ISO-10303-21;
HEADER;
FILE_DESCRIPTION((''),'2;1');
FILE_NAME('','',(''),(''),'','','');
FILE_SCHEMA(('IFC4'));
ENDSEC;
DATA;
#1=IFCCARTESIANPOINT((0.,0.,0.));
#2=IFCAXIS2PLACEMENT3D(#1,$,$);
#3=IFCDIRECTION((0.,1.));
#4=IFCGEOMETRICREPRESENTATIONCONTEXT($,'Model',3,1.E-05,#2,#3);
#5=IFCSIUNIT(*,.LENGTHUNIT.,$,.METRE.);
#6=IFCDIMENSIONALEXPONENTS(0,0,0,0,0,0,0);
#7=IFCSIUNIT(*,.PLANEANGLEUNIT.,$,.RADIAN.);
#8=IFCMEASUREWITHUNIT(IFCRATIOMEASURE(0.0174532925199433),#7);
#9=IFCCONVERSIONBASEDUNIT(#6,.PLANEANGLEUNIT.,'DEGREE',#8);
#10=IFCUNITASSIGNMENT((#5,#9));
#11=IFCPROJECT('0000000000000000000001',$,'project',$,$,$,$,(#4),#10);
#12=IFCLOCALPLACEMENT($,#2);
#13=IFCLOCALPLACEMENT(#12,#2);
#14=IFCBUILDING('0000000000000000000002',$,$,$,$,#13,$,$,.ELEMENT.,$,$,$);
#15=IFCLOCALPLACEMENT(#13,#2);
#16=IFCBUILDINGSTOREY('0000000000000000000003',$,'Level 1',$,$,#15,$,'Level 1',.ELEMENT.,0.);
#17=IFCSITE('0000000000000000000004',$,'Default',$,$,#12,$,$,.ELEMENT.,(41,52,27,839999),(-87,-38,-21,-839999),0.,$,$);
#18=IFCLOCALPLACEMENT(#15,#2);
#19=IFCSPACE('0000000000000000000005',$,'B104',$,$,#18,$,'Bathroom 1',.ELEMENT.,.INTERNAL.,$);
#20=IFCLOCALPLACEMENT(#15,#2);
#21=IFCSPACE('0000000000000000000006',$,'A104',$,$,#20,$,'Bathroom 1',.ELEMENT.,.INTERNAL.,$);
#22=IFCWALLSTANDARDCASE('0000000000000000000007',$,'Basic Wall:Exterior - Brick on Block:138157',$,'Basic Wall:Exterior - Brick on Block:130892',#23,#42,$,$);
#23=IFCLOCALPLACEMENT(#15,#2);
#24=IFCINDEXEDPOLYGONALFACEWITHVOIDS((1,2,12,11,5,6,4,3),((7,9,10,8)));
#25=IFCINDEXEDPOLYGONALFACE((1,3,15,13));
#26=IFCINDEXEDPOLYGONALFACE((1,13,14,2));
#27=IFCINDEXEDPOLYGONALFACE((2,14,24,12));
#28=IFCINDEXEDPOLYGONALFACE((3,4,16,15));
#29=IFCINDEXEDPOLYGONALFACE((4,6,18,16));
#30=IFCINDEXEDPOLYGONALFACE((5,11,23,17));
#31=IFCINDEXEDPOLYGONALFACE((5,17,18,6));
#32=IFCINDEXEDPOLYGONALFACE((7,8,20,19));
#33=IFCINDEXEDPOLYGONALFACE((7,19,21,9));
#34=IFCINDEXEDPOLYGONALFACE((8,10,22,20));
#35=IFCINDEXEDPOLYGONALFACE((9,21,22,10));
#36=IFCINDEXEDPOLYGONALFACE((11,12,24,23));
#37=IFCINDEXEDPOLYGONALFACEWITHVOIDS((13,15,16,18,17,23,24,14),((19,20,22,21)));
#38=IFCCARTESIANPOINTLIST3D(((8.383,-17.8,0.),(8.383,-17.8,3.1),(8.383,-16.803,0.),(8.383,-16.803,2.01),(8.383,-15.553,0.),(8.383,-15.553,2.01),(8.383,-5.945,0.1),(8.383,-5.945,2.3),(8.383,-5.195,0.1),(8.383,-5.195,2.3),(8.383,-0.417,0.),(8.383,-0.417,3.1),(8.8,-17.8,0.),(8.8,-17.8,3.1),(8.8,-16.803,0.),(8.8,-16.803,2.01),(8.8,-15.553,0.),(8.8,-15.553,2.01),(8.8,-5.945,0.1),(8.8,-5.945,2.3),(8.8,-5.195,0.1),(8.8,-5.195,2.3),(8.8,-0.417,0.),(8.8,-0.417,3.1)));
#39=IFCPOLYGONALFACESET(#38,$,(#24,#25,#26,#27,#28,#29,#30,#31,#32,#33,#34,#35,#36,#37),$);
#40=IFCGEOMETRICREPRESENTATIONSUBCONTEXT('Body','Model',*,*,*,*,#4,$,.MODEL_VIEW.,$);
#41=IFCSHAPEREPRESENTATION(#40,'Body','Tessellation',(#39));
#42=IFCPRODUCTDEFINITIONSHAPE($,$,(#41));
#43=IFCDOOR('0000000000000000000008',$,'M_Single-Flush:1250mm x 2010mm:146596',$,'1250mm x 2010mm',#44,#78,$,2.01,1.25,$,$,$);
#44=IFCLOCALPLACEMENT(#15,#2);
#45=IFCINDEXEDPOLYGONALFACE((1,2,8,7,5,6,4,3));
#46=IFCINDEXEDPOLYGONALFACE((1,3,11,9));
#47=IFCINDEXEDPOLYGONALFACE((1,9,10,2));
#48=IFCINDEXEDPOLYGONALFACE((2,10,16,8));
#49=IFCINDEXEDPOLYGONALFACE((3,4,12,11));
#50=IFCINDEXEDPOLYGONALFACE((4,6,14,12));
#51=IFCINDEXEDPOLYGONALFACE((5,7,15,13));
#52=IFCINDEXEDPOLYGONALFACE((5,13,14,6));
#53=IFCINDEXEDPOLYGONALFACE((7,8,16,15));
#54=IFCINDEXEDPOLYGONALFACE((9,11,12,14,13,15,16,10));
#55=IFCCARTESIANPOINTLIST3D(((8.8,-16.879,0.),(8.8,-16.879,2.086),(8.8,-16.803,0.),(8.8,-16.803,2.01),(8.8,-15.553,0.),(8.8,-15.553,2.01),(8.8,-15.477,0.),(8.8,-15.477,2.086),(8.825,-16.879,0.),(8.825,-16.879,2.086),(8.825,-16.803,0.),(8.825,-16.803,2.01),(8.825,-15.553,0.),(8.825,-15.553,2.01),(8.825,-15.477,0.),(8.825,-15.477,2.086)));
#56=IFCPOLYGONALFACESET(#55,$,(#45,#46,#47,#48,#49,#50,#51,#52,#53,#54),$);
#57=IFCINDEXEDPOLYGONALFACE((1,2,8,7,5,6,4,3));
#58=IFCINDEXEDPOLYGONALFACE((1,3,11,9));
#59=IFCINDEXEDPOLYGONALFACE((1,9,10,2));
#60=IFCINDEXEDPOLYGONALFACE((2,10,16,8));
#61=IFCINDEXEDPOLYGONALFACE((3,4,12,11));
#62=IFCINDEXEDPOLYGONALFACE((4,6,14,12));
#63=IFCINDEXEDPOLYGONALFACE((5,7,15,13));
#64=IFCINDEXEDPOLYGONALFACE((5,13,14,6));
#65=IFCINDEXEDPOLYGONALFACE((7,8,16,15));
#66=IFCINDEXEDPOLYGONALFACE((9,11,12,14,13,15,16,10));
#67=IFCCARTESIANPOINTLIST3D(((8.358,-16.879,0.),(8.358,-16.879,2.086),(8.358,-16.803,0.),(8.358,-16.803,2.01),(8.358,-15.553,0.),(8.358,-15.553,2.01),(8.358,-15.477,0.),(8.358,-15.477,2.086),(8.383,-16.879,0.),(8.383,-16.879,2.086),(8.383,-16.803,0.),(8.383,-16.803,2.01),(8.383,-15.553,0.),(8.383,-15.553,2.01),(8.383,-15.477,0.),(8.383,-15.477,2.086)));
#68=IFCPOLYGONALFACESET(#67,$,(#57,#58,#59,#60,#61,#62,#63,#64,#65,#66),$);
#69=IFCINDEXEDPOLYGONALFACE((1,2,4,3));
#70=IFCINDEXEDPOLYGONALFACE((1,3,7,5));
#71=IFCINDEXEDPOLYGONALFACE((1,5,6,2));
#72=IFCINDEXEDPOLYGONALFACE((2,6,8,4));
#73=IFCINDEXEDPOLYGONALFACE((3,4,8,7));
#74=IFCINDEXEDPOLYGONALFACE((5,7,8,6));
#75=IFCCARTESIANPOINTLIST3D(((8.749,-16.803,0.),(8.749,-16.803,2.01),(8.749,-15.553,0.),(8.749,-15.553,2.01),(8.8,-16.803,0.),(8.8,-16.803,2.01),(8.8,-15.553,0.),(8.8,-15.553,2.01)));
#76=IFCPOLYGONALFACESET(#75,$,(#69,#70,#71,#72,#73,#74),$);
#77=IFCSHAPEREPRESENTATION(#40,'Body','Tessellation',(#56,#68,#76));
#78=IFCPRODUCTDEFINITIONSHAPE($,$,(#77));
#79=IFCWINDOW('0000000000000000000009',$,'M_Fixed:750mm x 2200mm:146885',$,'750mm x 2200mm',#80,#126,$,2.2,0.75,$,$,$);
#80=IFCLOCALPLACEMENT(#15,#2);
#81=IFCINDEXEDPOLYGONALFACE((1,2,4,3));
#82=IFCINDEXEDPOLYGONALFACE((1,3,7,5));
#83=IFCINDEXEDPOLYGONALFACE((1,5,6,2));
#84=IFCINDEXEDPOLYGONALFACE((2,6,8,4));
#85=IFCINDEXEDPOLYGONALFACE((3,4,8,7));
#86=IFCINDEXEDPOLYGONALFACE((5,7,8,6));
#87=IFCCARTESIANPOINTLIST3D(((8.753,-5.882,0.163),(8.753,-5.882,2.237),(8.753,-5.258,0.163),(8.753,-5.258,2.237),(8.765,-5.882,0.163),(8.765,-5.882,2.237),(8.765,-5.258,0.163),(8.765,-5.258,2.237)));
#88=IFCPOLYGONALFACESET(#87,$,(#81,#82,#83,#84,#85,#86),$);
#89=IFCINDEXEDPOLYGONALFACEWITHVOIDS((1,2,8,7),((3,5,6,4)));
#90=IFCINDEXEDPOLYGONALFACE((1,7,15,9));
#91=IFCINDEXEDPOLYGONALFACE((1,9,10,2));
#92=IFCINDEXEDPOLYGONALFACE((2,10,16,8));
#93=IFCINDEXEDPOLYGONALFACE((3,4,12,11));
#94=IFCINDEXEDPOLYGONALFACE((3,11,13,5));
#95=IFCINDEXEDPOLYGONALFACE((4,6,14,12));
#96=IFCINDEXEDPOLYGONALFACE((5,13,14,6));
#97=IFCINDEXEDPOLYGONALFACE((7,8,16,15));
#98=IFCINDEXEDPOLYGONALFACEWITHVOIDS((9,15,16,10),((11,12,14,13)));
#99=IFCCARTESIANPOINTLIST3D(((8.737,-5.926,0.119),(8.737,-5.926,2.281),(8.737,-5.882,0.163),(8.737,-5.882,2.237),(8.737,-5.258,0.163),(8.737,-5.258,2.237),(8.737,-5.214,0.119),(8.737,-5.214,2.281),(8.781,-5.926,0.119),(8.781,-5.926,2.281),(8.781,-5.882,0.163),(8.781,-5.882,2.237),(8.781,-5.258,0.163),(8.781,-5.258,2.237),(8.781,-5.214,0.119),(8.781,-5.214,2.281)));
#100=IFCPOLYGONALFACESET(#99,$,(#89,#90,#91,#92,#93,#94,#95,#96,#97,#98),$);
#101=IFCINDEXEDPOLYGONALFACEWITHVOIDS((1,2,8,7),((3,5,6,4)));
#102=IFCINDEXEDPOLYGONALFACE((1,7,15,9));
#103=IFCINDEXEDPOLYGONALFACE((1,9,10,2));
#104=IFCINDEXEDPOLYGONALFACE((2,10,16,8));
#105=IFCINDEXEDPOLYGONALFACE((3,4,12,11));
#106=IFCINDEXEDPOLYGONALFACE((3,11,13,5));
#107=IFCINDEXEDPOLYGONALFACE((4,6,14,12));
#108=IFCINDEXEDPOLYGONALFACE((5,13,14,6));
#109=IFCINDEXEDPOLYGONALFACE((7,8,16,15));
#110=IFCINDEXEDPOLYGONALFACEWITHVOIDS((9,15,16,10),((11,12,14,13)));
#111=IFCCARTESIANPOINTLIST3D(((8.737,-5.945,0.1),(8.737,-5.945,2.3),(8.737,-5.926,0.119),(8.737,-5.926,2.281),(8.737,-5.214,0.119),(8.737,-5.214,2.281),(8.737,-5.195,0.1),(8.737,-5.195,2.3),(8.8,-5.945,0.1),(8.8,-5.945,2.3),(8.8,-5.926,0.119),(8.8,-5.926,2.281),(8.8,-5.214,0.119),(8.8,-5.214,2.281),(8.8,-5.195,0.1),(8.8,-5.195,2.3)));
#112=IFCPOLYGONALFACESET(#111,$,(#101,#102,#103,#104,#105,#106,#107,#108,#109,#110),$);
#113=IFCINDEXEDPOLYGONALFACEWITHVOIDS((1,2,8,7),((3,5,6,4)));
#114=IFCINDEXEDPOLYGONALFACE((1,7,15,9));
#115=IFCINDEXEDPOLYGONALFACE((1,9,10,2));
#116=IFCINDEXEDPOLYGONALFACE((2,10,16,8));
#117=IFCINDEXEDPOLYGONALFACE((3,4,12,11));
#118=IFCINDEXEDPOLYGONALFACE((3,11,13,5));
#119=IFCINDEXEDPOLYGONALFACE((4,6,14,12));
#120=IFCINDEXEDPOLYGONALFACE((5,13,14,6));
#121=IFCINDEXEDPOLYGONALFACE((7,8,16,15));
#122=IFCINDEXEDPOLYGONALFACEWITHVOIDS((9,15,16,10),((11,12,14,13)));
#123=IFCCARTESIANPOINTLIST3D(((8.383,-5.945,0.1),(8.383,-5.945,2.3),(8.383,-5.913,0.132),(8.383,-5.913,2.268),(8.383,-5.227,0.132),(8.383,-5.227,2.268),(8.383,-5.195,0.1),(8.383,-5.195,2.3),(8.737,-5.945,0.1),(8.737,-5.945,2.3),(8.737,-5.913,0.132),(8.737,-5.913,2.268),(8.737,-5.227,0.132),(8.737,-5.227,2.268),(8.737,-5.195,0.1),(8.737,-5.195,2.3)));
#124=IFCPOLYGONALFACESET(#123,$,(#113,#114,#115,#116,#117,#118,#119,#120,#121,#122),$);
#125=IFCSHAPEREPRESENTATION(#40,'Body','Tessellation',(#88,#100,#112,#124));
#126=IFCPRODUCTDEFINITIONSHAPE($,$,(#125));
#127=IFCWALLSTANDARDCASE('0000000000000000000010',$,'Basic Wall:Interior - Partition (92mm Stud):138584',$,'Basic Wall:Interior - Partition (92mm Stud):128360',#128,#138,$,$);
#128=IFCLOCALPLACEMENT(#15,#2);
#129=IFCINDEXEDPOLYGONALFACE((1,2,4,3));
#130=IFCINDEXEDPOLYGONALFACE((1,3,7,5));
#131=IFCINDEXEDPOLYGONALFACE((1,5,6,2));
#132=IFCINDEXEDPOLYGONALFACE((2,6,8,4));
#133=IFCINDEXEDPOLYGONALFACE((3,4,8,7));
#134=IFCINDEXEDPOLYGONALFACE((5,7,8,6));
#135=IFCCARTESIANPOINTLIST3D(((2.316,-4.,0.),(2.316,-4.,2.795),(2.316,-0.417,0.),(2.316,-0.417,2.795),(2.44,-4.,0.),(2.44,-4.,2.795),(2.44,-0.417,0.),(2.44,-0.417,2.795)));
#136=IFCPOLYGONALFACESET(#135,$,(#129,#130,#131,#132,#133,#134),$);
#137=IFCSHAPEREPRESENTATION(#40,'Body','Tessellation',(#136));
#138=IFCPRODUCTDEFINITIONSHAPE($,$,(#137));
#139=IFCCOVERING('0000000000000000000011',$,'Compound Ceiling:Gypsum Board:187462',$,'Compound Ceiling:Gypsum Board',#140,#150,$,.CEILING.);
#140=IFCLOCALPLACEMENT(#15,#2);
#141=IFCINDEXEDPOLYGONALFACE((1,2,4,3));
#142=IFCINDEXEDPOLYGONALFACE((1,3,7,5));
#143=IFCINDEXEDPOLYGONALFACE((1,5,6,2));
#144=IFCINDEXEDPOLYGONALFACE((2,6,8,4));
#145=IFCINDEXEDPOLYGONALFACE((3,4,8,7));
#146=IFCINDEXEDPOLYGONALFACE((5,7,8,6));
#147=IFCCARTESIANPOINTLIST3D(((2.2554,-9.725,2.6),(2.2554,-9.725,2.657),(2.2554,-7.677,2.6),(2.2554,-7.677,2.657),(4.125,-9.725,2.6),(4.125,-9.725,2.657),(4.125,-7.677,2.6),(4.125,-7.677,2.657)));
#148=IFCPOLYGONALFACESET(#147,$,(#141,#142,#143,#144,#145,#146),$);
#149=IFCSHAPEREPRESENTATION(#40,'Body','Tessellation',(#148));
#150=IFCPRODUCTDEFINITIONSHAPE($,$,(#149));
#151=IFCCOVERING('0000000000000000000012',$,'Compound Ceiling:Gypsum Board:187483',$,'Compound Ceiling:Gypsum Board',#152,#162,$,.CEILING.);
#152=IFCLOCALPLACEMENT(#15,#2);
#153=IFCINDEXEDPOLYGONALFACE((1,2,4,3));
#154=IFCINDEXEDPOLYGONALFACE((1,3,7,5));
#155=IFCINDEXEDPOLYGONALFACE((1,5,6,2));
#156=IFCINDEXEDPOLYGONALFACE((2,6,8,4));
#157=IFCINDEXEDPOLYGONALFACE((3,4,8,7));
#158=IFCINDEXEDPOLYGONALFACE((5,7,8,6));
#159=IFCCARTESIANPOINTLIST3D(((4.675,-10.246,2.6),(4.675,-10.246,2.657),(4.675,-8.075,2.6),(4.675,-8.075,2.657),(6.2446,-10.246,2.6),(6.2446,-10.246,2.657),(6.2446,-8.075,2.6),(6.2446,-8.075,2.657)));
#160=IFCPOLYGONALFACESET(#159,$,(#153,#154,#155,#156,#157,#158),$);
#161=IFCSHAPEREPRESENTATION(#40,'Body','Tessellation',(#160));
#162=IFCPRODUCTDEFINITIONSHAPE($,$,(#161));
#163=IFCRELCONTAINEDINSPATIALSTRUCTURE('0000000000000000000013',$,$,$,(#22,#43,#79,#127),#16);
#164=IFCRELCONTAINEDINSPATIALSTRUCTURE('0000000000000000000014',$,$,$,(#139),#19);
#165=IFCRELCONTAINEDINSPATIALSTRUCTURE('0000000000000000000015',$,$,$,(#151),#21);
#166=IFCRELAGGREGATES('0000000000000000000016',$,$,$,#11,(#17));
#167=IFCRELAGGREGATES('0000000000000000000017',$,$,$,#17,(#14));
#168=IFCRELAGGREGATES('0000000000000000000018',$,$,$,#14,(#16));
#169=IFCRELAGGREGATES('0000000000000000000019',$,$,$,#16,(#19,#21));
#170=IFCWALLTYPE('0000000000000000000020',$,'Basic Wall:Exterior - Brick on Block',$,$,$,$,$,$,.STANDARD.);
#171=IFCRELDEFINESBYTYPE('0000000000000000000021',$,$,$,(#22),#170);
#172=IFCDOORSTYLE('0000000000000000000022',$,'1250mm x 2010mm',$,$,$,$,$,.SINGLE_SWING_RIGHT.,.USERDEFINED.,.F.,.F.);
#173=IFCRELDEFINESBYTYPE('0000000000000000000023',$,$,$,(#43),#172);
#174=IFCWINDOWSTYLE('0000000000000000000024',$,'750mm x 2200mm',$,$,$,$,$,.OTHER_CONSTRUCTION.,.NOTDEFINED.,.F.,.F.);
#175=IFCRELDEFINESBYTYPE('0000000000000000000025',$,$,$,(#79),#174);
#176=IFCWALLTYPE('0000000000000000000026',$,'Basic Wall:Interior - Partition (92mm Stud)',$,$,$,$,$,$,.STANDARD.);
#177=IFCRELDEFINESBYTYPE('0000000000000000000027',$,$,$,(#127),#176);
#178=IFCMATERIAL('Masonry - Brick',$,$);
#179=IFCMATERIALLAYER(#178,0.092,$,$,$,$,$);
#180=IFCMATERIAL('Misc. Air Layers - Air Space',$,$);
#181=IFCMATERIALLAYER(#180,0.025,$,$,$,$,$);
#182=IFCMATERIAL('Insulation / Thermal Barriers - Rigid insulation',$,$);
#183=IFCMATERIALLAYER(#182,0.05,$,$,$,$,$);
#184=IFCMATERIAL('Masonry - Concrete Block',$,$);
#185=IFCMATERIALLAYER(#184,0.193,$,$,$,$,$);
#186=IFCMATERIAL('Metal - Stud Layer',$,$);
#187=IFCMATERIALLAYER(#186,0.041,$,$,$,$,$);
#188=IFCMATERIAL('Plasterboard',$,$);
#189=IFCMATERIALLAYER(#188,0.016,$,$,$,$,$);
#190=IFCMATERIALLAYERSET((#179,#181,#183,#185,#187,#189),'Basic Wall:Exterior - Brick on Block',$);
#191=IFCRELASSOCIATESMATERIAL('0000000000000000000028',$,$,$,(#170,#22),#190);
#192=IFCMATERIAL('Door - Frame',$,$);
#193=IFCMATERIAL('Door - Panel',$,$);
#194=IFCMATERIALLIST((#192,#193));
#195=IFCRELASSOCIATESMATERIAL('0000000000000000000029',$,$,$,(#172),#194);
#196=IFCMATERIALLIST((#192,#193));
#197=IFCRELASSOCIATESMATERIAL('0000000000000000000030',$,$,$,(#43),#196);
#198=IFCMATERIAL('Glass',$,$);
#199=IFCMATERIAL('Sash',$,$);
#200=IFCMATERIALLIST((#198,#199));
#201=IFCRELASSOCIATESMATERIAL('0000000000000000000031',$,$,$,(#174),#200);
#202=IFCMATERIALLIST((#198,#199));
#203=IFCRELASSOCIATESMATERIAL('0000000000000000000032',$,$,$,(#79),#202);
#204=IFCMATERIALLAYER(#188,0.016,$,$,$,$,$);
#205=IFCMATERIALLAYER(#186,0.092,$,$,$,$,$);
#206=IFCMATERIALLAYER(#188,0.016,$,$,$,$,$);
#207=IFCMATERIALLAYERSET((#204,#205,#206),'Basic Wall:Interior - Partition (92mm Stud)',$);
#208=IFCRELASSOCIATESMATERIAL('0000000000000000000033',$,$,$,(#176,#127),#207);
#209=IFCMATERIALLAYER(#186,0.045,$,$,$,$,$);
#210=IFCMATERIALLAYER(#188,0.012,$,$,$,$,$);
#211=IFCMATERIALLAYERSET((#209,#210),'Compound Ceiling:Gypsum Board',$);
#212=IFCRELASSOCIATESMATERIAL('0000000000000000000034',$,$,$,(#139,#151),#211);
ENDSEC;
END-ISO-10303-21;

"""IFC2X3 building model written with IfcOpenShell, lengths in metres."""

from ifc_helpers import new_model, entity, si_unit, converted_unit, direction, frame, frame_2d, origin, origin_2d_with_axis, place, context, subcontext, project, spatial, polyline, rectangle, outline, extrude, source, transform, mapped, material, material_list, layer, layer_set, layer_usage, type_object, type_shapes, element, fill, save


model = new_model("IFC2X3")

# Units and contexts
model_context = context("Model", 3, precision=1e-05, world=origin(), true_north=direction((0.0, 1.0)))
body_context = subcontext(model_context, "Body", "Model", "MODEL_VIEW")
ifc_project = project(units=[si_unit("LENGTHUNIT", "METRE"), converted_unit("PLANEANGLEUNIT", "DEGREE", entity("IfcRatioMeasure", 0.0174532925199433), si_unit("PLANEANGLEUNIT", "RADIAN"), dimensions=[0, 0, 0, 0, 0, 0, 0])], contexts=[model_context])

# Site, building, storey
site_placement = place(None, origin())
site = spatial("IfcSite", under=ifc_project, at=site_placement, Name="Default", CompositionType="ELEMENT", RefLatitude=(41, 52, 27, 839999), RefLongitude=(-87, -38, -21, -839999), RefElevation=0.0)
building_placement = place(site_placement, origin())
building = spatial("IfcBuilding", under=site, at=building_placement, CompositionType="ELEMENT")
storey_placement = place(building_placement, origin())
storey = spatial("IfcBuildingStorey", under=building, at=storey_placement, Name="Level 1", LongName="Level 1", CompositionType="ELEMENT", Elevation=0.0)

# Shared definitions
ifc_material_1 = material(Name="Masonry - Brick")
ifc_layer_1 = layer(ifc_material_1, 0.092)
ifc_material_2 = material(Name="Misc. Air Layers - Air Space")
ifc_layer_2 = layer(ifc_material_2, 0.025)
ifc_material_3 = material(Name="Insulation / Thermal Barriers - Rigid insulation")
ifc_layer_3 = layer(ifc_material_3, 0.05)
ifc_material_4 = material(Name="Masonry - Concrete Block")
ifc_layer_4 = layer(ifc_material_4, 0.193)
ifc_material_5 = material(Name="Metal - Stud Layer")
ifc_layer_5 = layer(ifc_material_5, 0.041)
ifc_material_6 = material(Name="Plasterboard")
ifc_layer_6 = layer(ifc_material_6, 0.016)
ifc_layer_set_1 = layer_set([ifc_layer_1, ifc_layer_2, ifc_layer_3, ifc_layer_4, ifc_layer_5, ifc_layer_6], Name="Basic Wall:Exterior - Brick on Block")
wall_type_1 = type_object("IfcWallType", Name="Basic Wall:Exterior - Brick on Block", PredefinedType="STANDARD", material=ifc_layer_set_1)
ifc_material_7 = material(Name="Glass")
ifc_material_8 = material(Name="Sash")
ifc_material_9 = material(Name="Door - Frame")
ifc_material_10 = material(Name="Door - Panel")

# Wall, openings, door, window
ifc_layer_usage_1 = layer_usage(ifc_layer_set_1, "AXIS2", "NEGATIVE", 0.2085)
wall_1_placement = place(storey_placement, frame((8.5915, -0.417, 0.0), z_axis=(0.0, 0.0, 1.0), x_axis=(0.0, -1.0, 0.0)))
wall_1 = element("IfcWallStandardCase", 1, at=wall_1_placement, inside=storey, type_object=wall_type_1, material=ifc_layer_usage_1, Name="Basic Wall:Exterior - Brick on Block:138157", ObjectType="Basic Wall:Exterior - Brick on Block:130892", context=body_context, shape_type="SweptSolid", body=[
    extrude(rectangle(XDim=17.383, YDim=0.417, at=frame_2d((8.6915, 0.0), x_axis=(-1.0, 0.0))), origin(), (0.0, 0.0, 1.0), 3.1),
])
opening_1_placement = place(wall_1_placement, frame((15.136, -0.2085, 0.0)))
opening_1 = element("IfcOpeningElement", 2, at=opening_1_placement, cuts=wall_1, ObjectType="Opening", context=body_context, shape_type="SweptSolid", body=[
    extrude(rectangle(XDim=1.25, YDim=2.01, at=frame_2d((1.005, 0.625), x_axis=(0.0, 1.0))), frame((0.0, 0.0, 0.0), z_axis=(0.0, 1.0, 0.0), x_axis=(0.0, 0.0, 1.0)), (0.0, 0.0, 1.0), 0.417),
])
opening_2_placement = place(wall_1_placement, frame((4.778, -0.2085, 0.1)))
opening_2 = element("IfcOpeningElement", 3, at=opening_2_placement, cuts=wall_1, ObjectType="Opening", context=body_context, shape_type="SweptSolid", body=[
    extrude(rectangle(XDim=2.2, YDim=0.75, at=frame_2d((1.1, 0.375), x_axis=(1.0, 0.0))), frame((0.0, 0.0, 0.0), z_axis=(0.0, 1.0, 0.0), x_axis=(0.0, 0.0, 1.0)), (0.0, 0.0, 1.0), 0.417),
])
ifc_material_list_1 = material_list([ifc_material_9, ifc_material_10])
ifc_material_list_2 = material_list([ifc_material_9, ifc_material_10])
door_style_1 = type_object("IfcDoorStyle", Name="1250mm x 2010mm", ConstructionType="USERDEFINED", OperationType="SINGLE_SWING_RIGHT", ParameterTakesPrecedence=False, Sizeable=False, material=ifc_material_list_2)
shared_shape_1 = source(origin(), body_context, "Body", "SweptSolid", [
    extrude(outline(polyline([(-0.701, -1.062), (0.701, -1.062), (0.701, 1.024), (0.625, 1.024), (0.625, -0.986), (-0.625, -0.986), (-0.625, 1.024), (-0.701, 1.024), (-0.701, -1.062)])), frame((0.625, 0.417, 1.024), z_axis=(0.0, 1.0, 0.0), x_axis=(1.0, 0.0, 0.0)), (0.0, 0.0, 1.0), 0.025),
    extrude(outline(polyline([(-1.062, -0.701), (1.024, -0.701), (1.024, -0.625), (-0.986, -0.625), (-0.986, 0.625), (1.024, 0.625), (1.024, 0.701), (-1.062, 0.701), (-1.062, -0.701)])), frame((0.625, -0.025, 1.024), z_axis=(0.0, 1.0, 0.0), x_axis=(0.0, 0.0, -1.0)), (0.0, 0.0, 1.0), 0.025),
    extrude(rectangle(XDim=0.051, YDim=1.25, at=frame_2d((0.0, 0.0), x_axis=(1.0, 0.0))), frame((0.625, 0.3915, 0.0), z_axis=(0.0, 0.0, 1.0), x_axis=(0.0, 1.0, 0.0)), (0.0, 0.0, 1.0), 2.01),
])
type_shapes(door_style_1, [shared_shape_1])
door_1_placement = place(opening_1_placement, origin())
door_1 = element("IfcDoor", 4, at=door_1_placement, inside=storey, type_object=door_style_1, material=ifc_material_list_1, Name="M_Single-Flush:1250mm x 2010mm:146596", ObjectType="1250mm x 2010mm", OverallHeight=2.01, OverallWidth=1.25, context=body_context, shape_type="MappedRepresentation", body=[
    mapped(shared_shape_1, transform((0.0, 0.0, 0.0), scale=1.0)),
])
fill(opening_1, door_1)
ifc_material_list_3 = material_list([ifc_material_7, ifc_material_8])
ifc_material_list_4 = material_list([ifc_material_7, ifc_material_8])
window_style_1 = type_object("IfcWindowStyle", Name="750mm x 2200mm", ConstructionType="OTHER_CONSTRUCTION", OperationType="NOTDEFINED", ParameterTakesPrecedence=False, Sizeable=False, material=ifc_material_list_4)
shared_shape_2 = source(origin(), body_context, "Body", "SweptSolid", [
    extrude(rectangle(XDim=0.012, YDim=0.624, at=origin_2d_with_axis()), frame((0.375, 0.376, 0.063), z_axis=(0.0, 0.0, 1.0), x_axis=(0.0, -1.0, 0.0)), (0.0, 0.0, 1.0), 2.074),
    extrude(outline(polyline([(-0.356, -1.081), (0.356, -1.081), (0.356, 1.081), (-0.356, 1.081), (-0.356, -1.081)]), holes=[polyline([(-0.312, -1.037), (-0.312, 1.037), (0.312, 1.037), (0.312, -1.037), (-0.312, -1.037)])]), frame((0.375, 0.354, 1.1), z_axis=(0.0, 1.0, 0.0), x_axis=(1.0, 0.0, 0.0)), (0.0, 0.0, 1.0), 0.044),
    extrude(outline(polyline([(-0.375, -1.1), (0.375, -1.1), (0.375, 1.1), (-0.375, 1.1), (-0.375, -1.1)]), holes=[polyline([(-0.356, -1.081), (-0.356, 1.081), (0.356, 1.081), (0.356, -1.081), (-0.356, -1.081)])]), frame((0.375, 0.354, 1.1), z_axis=(0.0, 1.0, 0.0), x_axis=(1.0, 0.0, 0.0)), (0.0, 0.0, 1.0), 0.063),
    extrude(outline(polyline([(-0.375, -1.1), (0.375, -1.1), (0.375, 1.1), (-0.375, 1.1), (-0.375, -1.1)]), holes=[polyline([(-0.343, -1.068), (-0.343, 1.068), (0.343, 1.068), (0.343, -1.068), (-0.343, -1.068)])]), frame((0.375, 0.0, 1.1), z_axis=(0.0, 1.0, 0.0), x_axis=(1.0, 0.0, 0.0)), (0.0, 0.0, 1.0), 0.354),
])
type_shapes(window_style_1, [shared_shape_2])
window_1_placement = place(opening_2_placement, origin())
window_1 = element("IfcWindow", 5, at=window_1_placement, inside=storey, type_object=window_style_1, material=ifc_material_list_3, Name="M_Fixed:750mm x 2200mm:146885", ObjectType="750mm x 2200mm", OverallHeight=2.2, OverallWidth=0.75, context=body_context, shape_type="MappedRepresentation", body=[
    mapped(shared_shape_2, transform((0.0, 0.0, 0.0), scale=1.0)),
])
fill(opening_2, window_1)

# Wall
ifc_layer_7 = layer(ifc_material_6, 0.016)
ifc_layer_8 = layer(ifc_material_5, 0.092)
ifc_layer_9 = layer(ifc_material_6, 0.016)
ifc_layer_set_2 = layer_set([ifc_layer_7, ifc_layer_8, ifc_layer_9], Name="Basic Wall:Interior - Partition (92mm Stud)")
ifc_layer_usage_2 = layer_usage(ifc_layer_set_2, "AXIS2", "NEGATIVE", 0.062)
wall_type_2 = type_object("IfcWallType", Name="Basic Wall:Interior - Partition (92mm Stud)", PredefinedType="STANDARD", material=ifc_layer_set_2)
wall_2_placement = place(storey_placement, frame((2.378, -0.417, 0.0), z_axis=(0.0, 0.0, 1.0), x_axis=(0.0, -1.0, 0.0)))
element("IfcWallStandardCase", 6, at=wall_2_placement, inside=storey, type_object=wall_type_2, material=ifc_layer_usage_2, Name="Basic Wall:Interior - Partition (92mm Stud):138584", ObjectType="Basic Wall:Interior - Partition (92mm Stud):128360", context=body_context, shape_type="SweptSolid", body=[
    extrude(rectangle(XDim=3.583, YDim=0.124, at=frame_2d((1.7915, 0.0), x_axis=(-1.0, 0.0))), origin(), (0.0, 0.0, 1.0), 2.795),
])

# Shared definitions
ifc_layer_10 = layer(ifc_material_5, 0.045)
ifc_layer_11 = layer(ifc_material_6, 0.012)
ifc_layer_set_3 = layer_set([ifc_layer_10, ifc_layer_11], Name="Compound Ceiling:Gypsum Board")

# Shared definitions
space_1_placement = place(storey_placement, origin())
space_1 = spatial("IfcSpace", under=storey, at=space_1_placement, Name="B104", LongName="Bathroom 1", CompositionType="ELEMENT", InteriorOrExteriorSpace="INTERNAL")

# Covering
ifc_layer_usage_3 = layer_usage(ifc_layer_set_3, "AXIS3", "POSITIVE", 0.0)
covering_1_placement = place(space_1_placement, origin())
element("IfcCovering", 7, at=covering_1_placement, inside=space_1, material=ifc_layer_usage_3, Name="Compound Ceiling:Gypsum Board:187462", ObjectType="Compound Ceiling:Gypsum Board", PredefinedType="CEILING", context=body_context, shape_type="SweptSolid", body=[
    extrude(rectangle(XDim=1.8696, YDim=2.048, at=frame_2d((0.0, 0.0), x_axis=(1.0, 0.0))), frame((3.1902, -8.701, 2.6)), (0.0, 0.0, 1.0), 0.057),
])

# Shared definitions
space_2_placement = place(storey_placement, origin())
space_2 = spatial("IfcSpace", under=storey, at=space_2_placement, Name="A104", LongName="Bathroom 1", CompositionType="ELEMENT", InteriorOrExteriorSpace="INTERNAL")

# Covering
ifc_layer_usage_4 = layer_usage(ifc_layer_set_3, "AXIS3", "POSITIVE", 0.0)
covering_2_placement = place(space_2_placement, origin())
element("IfcCovering", 8, at=covering_2_placement, inside=space_2, material=ifc_layer_usage_4, Name="Compound Ceiling:Gypsum Board:187483", ObjectType="Compound Ceiling:Gypsum Board", PredefinedType="CEILING", context=body_context, shape_type="SweptSolid", body=[
    extrude(rectangle(XDim=2.171, YDim=1.5696, at=frame_2d((0.0, 0.0), x_axis=(1.0, 0.0))), frame((5.4598, -9.1605, 2.6), z_axis=(0.0, 0.0, 1.0), x_axis=(0.0, -1.0, 0.0)), (0.0, 0.0, 1.0), 0.057),
])

save(model, "model.ifc")
